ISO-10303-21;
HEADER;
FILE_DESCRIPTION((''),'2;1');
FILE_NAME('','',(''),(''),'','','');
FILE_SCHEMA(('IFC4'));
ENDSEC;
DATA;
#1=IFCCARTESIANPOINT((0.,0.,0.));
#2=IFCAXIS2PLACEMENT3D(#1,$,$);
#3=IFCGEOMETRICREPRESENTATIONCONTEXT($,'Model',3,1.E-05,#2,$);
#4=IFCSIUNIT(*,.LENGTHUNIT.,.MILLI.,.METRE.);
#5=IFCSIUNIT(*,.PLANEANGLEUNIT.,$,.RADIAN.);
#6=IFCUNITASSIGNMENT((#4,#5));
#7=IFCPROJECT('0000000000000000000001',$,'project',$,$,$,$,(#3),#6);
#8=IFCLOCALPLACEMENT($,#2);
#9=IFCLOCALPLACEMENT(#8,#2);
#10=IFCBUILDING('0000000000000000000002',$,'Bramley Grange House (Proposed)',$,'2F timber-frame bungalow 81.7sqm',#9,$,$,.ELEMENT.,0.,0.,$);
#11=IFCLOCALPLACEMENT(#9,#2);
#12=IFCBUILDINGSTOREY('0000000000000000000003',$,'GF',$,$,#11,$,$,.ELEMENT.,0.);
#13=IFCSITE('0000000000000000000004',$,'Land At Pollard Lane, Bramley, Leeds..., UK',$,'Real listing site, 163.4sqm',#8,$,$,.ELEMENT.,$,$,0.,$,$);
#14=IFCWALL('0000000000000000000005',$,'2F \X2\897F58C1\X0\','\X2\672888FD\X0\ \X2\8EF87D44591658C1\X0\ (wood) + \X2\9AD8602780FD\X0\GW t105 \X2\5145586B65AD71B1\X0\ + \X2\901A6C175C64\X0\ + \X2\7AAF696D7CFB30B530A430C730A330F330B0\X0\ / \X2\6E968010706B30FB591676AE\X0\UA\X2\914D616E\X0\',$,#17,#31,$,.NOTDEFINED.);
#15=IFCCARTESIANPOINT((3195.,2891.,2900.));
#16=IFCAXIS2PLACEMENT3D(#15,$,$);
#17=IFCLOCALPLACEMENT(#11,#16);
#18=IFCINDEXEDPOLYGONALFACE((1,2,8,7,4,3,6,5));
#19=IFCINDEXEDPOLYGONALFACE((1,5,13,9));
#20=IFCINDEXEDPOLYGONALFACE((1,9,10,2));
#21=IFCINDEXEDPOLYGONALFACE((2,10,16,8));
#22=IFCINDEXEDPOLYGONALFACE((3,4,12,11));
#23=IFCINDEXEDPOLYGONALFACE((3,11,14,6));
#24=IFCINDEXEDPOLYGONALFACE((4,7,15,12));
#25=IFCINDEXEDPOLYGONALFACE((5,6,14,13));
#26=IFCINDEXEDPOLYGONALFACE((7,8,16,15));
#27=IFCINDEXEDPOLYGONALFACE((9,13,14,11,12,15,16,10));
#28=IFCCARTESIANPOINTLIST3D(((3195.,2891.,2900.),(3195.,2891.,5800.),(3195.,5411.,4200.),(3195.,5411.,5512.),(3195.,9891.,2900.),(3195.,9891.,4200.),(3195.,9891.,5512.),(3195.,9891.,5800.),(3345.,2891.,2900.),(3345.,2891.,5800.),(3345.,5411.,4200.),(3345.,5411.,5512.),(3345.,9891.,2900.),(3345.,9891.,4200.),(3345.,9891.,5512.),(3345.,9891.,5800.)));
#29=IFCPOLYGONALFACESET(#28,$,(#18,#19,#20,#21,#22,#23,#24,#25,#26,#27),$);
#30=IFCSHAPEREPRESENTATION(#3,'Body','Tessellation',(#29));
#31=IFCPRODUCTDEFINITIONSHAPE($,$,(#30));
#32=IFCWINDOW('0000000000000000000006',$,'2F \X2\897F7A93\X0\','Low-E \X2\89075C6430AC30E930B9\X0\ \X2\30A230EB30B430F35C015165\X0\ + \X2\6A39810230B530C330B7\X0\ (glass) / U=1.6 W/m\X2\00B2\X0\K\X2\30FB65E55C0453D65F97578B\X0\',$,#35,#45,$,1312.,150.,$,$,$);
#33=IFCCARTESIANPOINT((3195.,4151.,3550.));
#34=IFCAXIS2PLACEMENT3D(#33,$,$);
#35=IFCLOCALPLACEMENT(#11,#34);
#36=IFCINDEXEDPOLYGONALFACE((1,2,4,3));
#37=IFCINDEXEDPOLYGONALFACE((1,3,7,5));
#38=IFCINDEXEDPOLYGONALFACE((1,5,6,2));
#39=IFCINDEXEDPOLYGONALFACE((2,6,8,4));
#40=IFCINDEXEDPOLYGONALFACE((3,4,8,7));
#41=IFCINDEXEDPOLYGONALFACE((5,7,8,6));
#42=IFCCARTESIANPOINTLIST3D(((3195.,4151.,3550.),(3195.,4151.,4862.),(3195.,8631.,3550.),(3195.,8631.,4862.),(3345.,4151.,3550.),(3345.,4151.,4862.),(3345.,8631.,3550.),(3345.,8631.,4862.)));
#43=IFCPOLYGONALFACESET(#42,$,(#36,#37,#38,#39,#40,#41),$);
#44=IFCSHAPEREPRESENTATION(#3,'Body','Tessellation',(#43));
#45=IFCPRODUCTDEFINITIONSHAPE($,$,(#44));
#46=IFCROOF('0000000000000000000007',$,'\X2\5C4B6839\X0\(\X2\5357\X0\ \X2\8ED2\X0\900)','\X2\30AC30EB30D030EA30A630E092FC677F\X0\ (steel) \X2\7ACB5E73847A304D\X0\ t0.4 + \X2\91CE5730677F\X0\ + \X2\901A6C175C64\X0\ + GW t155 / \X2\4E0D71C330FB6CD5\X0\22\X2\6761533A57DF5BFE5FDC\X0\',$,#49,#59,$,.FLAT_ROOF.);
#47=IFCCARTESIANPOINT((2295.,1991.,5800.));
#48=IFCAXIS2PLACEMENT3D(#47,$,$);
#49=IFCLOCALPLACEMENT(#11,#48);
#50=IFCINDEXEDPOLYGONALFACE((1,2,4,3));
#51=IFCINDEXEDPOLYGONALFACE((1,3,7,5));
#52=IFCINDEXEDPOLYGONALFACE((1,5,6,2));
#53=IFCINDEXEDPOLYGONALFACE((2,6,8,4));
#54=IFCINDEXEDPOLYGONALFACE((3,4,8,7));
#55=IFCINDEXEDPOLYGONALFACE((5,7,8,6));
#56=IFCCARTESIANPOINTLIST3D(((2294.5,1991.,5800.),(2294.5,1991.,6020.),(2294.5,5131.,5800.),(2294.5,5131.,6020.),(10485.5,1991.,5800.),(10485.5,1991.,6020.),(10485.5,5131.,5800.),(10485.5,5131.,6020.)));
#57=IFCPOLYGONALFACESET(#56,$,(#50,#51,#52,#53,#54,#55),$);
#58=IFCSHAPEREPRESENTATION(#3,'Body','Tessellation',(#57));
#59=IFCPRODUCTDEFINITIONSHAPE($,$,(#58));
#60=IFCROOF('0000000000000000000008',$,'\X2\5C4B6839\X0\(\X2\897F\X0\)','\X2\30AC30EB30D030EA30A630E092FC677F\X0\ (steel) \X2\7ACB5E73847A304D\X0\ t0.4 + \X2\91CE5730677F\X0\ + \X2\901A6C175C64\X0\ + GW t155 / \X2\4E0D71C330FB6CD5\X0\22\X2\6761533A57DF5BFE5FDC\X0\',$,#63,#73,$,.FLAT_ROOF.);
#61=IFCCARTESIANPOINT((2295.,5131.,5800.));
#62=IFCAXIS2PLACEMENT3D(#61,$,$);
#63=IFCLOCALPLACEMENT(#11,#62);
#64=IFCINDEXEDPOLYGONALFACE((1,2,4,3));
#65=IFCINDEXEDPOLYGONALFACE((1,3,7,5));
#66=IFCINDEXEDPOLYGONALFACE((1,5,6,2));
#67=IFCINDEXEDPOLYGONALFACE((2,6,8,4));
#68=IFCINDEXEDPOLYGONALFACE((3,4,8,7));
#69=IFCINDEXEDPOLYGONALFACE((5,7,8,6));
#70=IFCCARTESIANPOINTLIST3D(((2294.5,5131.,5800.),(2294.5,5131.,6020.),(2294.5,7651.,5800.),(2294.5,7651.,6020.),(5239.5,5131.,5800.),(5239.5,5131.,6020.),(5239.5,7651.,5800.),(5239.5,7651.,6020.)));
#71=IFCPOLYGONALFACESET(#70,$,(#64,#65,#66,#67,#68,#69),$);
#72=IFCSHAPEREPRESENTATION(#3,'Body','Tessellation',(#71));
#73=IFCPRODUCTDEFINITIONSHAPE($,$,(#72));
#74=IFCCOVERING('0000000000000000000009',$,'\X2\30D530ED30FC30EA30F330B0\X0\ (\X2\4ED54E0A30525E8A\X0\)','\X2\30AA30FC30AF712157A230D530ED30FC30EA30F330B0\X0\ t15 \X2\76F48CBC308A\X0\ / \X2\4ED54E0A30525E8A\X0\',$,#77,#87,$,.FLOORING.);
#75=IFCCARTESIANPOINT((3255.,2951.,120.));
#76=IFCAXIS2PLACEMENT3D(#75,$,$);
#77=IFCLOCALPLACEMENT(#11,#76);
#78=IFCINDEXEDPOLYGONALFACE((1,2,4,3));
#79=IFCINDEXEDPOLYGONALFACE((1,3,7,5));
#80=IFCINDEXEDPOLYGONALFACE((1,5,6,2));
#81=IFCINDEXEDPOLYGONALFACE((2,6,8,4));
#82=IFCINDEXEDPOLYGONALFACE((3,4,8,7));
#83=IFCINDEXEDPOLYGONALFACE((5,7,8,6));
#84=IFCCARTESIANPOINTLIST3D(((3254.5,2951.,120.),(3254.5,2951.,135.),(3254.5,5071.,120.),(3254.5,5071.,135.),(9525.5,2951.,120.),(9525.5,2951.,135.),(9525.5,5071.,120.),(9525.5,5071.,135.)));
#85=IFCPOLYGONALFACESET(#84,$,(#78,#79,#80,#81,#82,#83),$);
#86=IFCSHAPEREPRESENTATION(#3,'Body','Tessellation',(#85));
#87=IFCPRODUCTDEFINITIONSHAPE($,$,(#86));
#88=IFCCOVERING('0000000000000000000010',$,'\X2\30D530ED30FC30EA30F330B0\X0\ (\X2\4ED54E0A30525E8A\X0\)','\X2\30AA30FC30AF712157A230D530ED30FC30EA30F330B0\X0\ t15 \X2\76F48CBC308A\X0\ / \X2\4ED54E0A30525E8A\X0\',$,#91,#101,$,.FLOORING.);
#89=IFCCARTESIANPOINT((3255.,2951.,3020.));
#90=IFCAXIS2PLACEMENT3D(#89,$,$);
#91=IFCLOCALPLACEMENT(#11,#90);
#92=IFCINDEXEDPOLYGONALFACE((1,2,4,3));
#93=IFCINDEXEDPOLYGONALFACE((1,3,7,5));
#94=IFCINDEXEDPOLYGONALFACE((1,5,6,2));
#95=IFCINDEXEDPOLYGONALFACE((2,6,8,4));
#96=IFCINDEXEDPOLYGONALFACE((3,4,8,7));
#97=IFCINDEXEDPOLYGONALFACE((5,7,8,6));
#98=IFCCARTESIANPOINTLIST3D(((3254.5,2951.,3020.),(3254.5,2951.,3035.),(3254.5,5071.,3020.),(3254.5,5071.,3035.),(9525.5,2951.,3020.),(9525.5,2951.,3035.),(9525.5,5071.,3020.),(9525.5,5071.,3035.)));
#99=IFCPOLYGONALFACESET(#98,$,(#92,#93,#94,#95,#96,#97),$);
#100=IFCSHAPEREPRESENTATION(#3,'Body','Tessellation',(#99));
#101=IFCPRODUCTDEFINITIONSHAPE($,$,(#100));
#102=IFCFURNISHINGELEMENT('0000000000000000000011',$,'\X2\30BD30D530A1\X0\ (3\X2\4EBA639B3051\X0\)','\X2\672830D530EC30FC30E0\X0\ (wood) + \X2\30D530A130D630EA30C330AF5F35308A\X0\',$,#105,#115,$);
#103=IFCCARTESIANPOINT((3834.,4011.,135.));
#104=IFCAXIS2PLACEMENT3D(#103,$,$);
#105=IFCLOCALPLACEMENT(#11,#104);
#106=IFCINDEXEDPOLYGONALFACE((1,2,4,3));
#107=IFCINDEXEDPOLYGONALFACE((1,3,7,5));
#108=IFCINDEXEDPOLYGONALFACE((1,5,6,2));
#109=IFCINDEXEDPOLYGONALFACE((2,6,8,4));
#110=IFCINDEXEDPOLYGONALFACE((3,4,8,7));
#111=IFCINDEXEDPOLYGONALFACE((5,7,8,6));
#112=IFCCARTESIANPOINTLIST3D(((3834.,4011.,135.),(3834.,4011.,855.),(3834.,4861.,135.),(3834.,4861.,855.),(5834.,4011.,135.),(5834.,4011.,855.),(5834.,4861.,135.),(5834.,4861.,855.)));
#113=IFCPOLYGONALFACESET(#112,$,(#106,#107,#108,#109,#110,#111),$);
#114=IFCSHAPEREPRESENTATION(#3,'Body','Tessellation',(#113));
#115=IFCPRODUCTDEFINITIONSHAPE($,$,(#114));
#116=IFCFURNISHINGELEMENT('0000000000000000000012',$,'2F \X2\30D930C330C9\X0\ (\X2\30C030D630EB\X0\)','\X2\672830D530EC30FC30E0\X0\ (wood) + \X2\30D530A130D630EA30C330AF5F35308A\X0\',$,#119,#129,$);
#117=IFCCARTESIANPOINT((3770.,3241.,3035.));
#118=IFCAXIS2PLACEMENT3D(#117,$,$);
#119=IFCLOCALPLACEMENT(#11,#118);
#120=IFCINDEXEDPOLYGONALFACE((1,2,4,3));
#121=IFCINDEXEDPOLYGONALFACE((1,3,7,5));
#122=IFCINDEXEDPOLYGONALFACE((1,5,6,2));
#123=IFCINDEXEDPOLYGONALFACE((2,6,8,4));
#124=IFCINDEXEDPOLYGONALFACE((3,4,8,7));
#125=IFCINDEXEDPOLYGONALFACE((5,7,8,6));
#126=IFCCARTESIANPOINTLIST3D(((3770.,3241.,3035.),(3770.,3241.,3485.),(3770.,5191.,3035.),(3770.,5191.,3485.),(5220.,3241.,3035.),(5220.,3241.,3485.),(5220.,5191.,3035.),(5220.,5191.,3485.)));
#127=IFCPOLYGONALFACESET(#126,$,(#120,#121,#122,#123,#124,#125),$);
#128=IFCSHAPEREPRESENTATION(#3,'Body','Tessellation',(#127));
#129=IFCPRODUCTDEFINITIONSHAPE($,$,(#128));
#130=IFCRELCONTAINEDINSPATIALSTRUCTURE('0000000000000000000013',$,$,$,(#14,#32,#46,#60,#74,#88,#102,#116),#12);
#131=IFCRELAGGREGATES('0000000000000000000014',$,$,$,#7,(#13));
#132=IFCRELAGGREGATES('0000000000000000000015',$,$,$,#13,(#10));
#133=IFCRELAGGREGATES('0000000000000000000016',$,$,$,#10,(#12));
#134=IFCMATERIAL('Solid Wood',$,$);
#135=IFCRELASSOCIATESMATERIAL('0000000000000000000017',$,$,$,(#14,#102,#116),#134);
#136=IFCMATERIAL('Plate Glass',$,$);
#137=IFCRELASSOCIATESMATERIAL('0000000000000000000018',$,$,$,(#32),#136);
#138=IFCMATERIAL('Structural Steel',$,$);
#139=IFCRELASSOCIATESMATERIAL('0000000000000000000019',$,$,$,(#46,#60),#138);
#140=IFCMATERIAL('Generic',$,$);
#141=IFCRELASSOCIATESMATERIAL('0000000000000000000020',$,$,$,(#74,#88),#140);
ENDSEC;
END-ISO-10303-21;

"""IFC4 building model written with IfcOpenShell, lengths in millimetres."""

from ifc_helpers import new_model, si_unit, frame, frame_2d, origin, place, context, project, spatial, rectangle, extrude, material, element, fill, save


model = new_model("IFC4")

# Units and contexts
model_context = context("Model", 3, precision=1e-05, world=origin())
ifc_project = project(units=[si_unit("LENGTHUNIT", "METRE", prefix="MILLI"), si_unit("PLANEANGLEUNIT", "RADIAN")], contexts=[model_context])

# Site, building, storey
site_placement = place(None, origin())
site = spatial("IfcSite", under=ifc_project, at=site_placement, Name="Land At Pollard Lane, Bramley, Leeds..., UK", ObjectType="Real listing site, 163.4sqm", CompositionType="ELEMENT", RefElevation=0.0)
building_placement = place(site_placement, origin())
building = spatial("IfcBuilding", under=site, at=building_placement, Name="Bramley Grange House (Proposed)", ObjectType="2F timber-frame bungalow 81.7sqm", CompositionType="ELEMENT", ElevationOfRefHeight=0.0, ElevationOfTerrain=0.0)
storey_placement = place(building_placement, origin())
storey = spatial("IfcBuildingStorey", under=building, at=storey_placement, Name="GF", CompositionType="ELEMENT", Elevation=0.0)

# Shared definitions
ifc_material_1 = material(Name="Solid Wood")

# Shared definitions
ifc_material_2 = material(Name="Plate Glass")

# Wall, opening, window
wall_1_placement = place(storey_placement, frame((3195.0, 2891.0, 2900.0)))
wall_1 = element("IfcWall", 1, at=wall_1_placement, inside=storey, material=ifc_material_1, Name="2F 西壁", Description="木製 軸組外壁 (wood) + 高性能GW t105 充填断熱 + 通気層 + 窯業系サイディング / 準耐火・外皮UA配慮", PredefinedType="NOTDEFINED", context=model_context, shape_type="SweptSolid", body=[
    extrude(rectangle(XDim=150.0, YDim=7000.0, at=frame_2d((75.0, 3500.0))), frame((3195.0, 2891.0, 2900.0)), (0.0, 0.0, 1.0), 2900.0),
])
opening_1_placement = place(storey_placement, frame((3195.0, 4151.0, 3550.0)))
opening_1 = element("IfcOpeningElement", 2, at=opening_1_placement, cuts=wall_1, PredefinedType="NOTDEFINED", context=model_context, shape_type="SweptSolid", body=[
    extrude(rectangle(XDim=150.0, YDim=4480.0, at=frame_2d((75.0, 2240.0))), frame((3195.0, 4151.0, 3550.0)), (0.0, 0.0, 1.0), 1312.0),
])
window_1_placement = place(storey_placement, frame((3195.0, 4151.0, 3550.0)))
window_1 = element("IfcWindow", 3, at=window_1_placement, inside=storey, material=ifc_material_2, Name="2F 西窓", Description="Low-E 複層ガラス アルゴン封入 + 樹脂サッシ (glass) / U=1.6 W/m²K・日射取得型", OverallHeight=1312.0, OverallWidth=150.0, context=model_context, shape_type="SweptSolid", body=[
    extrude(rectangle(XDim=150.0, YDim=4480.0, at=frame_2d((75.0, 2240.0))), frame((3195.0, 4151.0, 3550.0)), (0.0, 0.0, 1.0), 1312.0),
])
fill(opening_1, window_1)

# Roofs
ifc_material_3 = material(Name="Structural Steel")
roof_1_placement = place(storey_placement, frame((2295.0, 1991.0, 5800.0)))
element("IfcRoof", 4, at=roof_1_placement, inside=storey, material=ifc_material_3, Name="屋根(南 軒900)", Description="ガルバリウム鋼板 (steel) 立平葺き t0.4 + 野地板 + 通気層 + GW t155 / 不燃・法22条区域対応", PredefinedType="FLAT_ROOF", context=model_context, shape_type="SweptSolid", body=[
    extrude(rectangle(XDim=8191.0, YDim=3140.0, at=frame_2d((4095.0, 1570.0))), frame((2295.0, 1991.0, 5800.0)), (0.0, 0.0, 1.0), 220.0),
])
roof_2_placement = place(storey_placement, frame((2295.0, 5131.0, 5800.0)))
element("IfcRoof", 5, at=roof_2_placement, inside=storey, material=ifc_material_3, Name="屋根(西)", Description="ガルバリウム鋼板 (steel) 立平葺き t0.4 + 野地板 + 通気層 + GW t155 / 不燃・法22条区域対応", PredefinedType="FLAT_ROOF", context=model_context, shape_type="SweptSolid", body=[
    extrude(rectangle(XDim=2945.0, YDim=2520.0, at=frame_2d((1472.0, 1260.0))), frame((2295.0, 5131.0, 5800.0)), (0.0, 0.0, 1.0), 220.0),
])

# Coverings
ifc_material_4 = material(Name="Generic")
covering_1_placement = place(storey_placement, frame((3255.0, 2951.0, 120.0)))
element("IfcCovering", 6, at=covering_1_placement, inside=storey, material=ifc_material_4, Name="フローリング (仕上げ床)", Description="オーク無垢フローリング t15 直貼り / 仕上げ床", PredefinedType="FLOORING", context=model_context, shape_type="SweptSolid", body=[
    extrude(rectangle(XDim=6271.0, YDim=2120.0, at=frame_2d((3135.0, 1060.0))), frame((3255.0, 2951.0, 120.0)), (0.0, 0.0, 1.0), 15.0),
])
covering_2_placement = place(storey_placement, frame((3255.0, 2951.0, 3020.0)))
element("IfcCovering", 7, at=covering_2_placement, inside=storey, material=ifc_material_4, Name="フローリング (仕上げ床)", Description="オーク無垢フローリング t15 直貼り / 仕上げ床", PredefinedType="FLOORING", context=model_context, shape_type="SweptSolid", body=[
    extrude(rectangle(XDim=6271.0, YDim=2120.0, at=frame_2d((3135.0, 1060.0))), frame((3255.0, 2951.0, 3020.0)), (0.0, 0.0, 1.0), 15.0),
])

# Furnishing elements
furnishing_1_placement = place(storey_placement, frame((3834.0, 4011.0, 135.0)))
element("IfcFurnishingElement", 8, at=furnishing_1_placement, inside=storey, material=ifc_material_1, Name="ソファ (3人掛け)", Description="木フレーム (wood) + ファブリック張り", context=model_context, shape_type="SweptSolid", body=[
    extrude(rectangle(XDim=2000.0, YDim=850.0, at=frame_2d((1000.0, 425.0))), frame((3834.0, 4011.0, 135.0)), (0.0, 0.0, 1.0), 720.0),
])
furnishing_2_placement = place(storey_placement, frame((3770.0, 3241.0, 3035.0)))
element("IfcFurnishingElement", 9, at=furnishing_2_placement, inside=storey, material=ifc_material_1, Name="2F ベッド (ダブル)", Description="木フレーム (wood) + ファブリック張り", context=model_context, shape_type="SweptSolid", body=[
    extrude(rectangle(XDim=1450.0, YDim=1950.0, at=frame_2d((725.0, 975.0))), frame((3770.0, 3241.0, 3035.0)), (0.0, 0.0, 1.0), 450.0),
])

save(model, "model.ifc")
